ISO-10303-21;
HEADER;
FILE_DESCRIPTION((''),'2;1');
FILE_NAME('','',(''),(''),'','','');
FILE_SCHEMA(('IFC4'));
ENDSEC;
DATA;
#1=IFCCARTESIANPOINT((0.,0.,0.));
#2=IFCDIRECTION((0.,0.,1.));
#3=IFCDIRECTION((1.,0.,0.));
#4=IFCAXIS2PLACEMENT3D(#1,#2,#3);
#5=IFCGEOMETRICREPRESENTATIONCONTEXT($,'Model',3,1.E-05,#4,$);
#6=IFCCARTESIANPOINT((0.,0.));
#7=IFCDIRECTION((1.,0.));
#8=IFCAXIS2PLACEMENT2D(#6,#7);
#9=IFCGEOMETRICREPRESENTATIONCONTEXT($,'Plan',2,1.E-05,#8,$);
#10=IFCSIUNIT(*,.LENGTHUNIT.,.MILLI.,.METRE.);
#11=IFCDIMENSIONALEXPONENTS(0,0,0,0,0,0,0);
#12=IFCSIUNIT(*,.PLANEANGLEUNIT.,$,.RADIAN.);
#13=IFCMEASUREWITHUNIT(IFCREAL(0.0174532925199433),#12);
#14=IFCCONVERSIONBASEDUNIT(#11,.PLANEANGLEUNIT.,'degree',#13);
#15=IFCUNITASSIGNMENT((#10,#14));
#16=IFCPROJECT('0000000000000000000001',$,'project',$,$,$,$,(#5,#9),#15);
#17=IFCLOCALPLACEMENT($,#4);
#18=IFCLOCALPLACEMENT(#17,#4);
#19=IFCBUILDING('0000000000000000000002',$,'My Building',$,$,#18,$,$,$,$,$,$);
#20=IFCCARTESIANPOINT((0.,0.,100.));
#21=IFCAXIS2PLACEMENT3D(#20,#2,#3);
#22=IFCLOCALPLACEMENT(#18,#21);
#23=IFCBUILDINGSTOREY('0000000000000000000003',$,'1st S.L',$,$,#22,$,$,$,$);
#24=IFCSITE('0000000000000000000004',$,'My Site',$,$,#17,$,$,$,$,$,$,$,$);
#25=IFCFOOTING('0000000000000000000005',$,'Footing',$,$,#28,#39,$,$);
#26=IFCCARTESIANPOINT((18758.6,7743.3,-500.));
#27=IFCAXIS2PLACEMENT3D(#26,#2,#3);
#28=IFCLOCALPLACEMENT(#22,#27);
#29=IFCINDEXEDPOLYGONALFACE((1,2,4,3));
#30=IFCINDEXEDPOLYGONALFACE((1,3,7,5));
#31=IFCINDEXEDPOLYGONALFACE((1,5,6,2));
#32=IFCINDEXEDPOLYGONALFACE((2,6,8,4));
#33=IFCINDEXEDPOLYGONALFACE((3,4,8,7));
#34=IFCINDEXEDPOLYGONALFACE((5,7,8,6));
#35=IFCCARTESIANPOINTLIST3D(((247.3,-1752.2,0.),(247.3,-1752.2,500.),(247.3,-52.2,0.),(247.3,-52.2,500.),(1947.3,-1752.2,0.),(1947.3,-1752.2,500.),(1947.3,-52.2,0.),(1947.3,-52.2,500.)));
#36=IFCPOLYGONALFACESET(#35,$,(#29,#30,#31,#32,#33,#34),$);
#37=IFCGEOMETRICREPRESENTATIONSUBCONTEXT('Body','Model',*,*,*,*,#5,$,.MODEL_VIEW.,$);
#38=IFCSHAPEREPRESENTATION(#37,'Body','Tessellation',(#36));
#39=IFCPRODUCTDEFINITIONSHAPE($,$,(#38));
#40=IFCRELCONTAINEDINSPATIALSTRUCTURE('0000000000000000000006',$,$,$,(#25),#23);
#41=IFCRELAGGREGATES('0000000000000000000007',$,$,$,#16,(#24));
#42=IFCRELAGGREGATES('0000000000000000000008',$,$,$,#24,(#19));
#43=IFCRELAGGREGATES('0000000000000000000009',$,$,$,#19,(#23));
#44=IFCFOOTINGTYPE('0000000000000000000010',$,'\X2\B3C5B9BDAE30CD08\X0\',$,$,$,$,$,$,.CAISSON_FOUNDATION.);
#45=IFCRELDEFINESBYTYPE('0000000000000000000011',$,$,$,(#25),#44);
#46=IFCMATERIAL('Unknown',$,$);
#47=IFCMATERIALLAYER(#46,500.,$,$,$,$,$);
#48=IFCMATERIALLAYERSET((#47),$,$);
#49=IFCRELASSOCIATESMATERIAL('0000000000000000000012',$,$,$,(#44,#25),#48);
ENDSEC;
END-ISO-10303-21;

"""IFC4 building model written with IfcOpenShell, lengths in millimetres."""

from ifc_helpers import new_model, entity, si_unit, converted_unit, frame, origin_with_axes, origin_2d_with_axis, place, context, subcontext, project, spatial, indexed_curve, outline, extrude, material, layer, layer_set, layer_usage, type_object, element, save


model = new_model("IFC4")

# Units and contexts
model_context = context("Model", 3, precision=1e-05, world=origin_with_axes())
plan_context = context("Plan", 2, precision=1e-05, world=origin_2d_with_axis())
body_context_1 = subcontext(model_context, "Body", "Model", "MODEL_VIEW")
ifc_project = project(units=[si_unit("LENGTHUNIT", "METRE", prefix="MILLI"), converted_unit("PLANEANGLEUNIT", "degree", entity("IfcReal", 0.0174532925199433), si_unit("PLANEANGLEUNIT", "RADIAN"), dimensions=[0, 0, 0, 0, 0, 0, 0])], contexts=[model_context, plan_context])

# Site, building, storey
site_placement = place(None, origin_with_axes())
site = spatial("IfcSite", under=ifc_project, at=site_placement, Name="My Site")
building_placement = place(site_placement, origin_with_axes())
building = spatial("IfcBuilding", under=site, at=building_placement, Name="My Building")
storey_placement = place(building_placement, frame((0.0, 0.0, 100.0), z_axis=(0.0, 0.0, 1.0), x_axis=(1.0, 0.0, 0.0)))
storey = spatial("IfcBuildingStorey", under=building, at=storey_placement, Name="1st S.L")

# Footing
ifc_material_1 = material(Name="Unknown")
ifc_layer_1 = layer(ifc_material_1, 500.0)
ifc_layer_set_1 = layer_set([ifc_layer_1])
ifc_layer_usage_1 = layer_usage(ifc_layer_set_1, "AXIS3", "POSITIVE", 0.0)
footing_type = type_object("IfcFootingType", Name="독립기초", PredefinedType="CAISSON_FOUNDATION", material=ifc_layer_set_1)
footing_placement = place(storey_placement, frame((18758.6, 7743.3, -500.0), z_axis=(0.0, 0.0, 1.0), x_axis=(1.0, 0.0, 0.0)))
element("IfcFooting", 1, at=footing_placement, inside=storey, type_object=footing_type, material=ifc_layer_usage_1, Name="Footing", context=body_context_1, shape_type="SolidModel", body=[
    extrude(outline(indexed_curve([(1947.3, -52.2), (1947.3, -1752.2), (247.3, -1752.2), (247.3, -52.2), (1947.3, -52.2)])), origin_with_axes(), (0.0, 0.0, 1.0), 500.0),
])

save(model, "model.ifc")
